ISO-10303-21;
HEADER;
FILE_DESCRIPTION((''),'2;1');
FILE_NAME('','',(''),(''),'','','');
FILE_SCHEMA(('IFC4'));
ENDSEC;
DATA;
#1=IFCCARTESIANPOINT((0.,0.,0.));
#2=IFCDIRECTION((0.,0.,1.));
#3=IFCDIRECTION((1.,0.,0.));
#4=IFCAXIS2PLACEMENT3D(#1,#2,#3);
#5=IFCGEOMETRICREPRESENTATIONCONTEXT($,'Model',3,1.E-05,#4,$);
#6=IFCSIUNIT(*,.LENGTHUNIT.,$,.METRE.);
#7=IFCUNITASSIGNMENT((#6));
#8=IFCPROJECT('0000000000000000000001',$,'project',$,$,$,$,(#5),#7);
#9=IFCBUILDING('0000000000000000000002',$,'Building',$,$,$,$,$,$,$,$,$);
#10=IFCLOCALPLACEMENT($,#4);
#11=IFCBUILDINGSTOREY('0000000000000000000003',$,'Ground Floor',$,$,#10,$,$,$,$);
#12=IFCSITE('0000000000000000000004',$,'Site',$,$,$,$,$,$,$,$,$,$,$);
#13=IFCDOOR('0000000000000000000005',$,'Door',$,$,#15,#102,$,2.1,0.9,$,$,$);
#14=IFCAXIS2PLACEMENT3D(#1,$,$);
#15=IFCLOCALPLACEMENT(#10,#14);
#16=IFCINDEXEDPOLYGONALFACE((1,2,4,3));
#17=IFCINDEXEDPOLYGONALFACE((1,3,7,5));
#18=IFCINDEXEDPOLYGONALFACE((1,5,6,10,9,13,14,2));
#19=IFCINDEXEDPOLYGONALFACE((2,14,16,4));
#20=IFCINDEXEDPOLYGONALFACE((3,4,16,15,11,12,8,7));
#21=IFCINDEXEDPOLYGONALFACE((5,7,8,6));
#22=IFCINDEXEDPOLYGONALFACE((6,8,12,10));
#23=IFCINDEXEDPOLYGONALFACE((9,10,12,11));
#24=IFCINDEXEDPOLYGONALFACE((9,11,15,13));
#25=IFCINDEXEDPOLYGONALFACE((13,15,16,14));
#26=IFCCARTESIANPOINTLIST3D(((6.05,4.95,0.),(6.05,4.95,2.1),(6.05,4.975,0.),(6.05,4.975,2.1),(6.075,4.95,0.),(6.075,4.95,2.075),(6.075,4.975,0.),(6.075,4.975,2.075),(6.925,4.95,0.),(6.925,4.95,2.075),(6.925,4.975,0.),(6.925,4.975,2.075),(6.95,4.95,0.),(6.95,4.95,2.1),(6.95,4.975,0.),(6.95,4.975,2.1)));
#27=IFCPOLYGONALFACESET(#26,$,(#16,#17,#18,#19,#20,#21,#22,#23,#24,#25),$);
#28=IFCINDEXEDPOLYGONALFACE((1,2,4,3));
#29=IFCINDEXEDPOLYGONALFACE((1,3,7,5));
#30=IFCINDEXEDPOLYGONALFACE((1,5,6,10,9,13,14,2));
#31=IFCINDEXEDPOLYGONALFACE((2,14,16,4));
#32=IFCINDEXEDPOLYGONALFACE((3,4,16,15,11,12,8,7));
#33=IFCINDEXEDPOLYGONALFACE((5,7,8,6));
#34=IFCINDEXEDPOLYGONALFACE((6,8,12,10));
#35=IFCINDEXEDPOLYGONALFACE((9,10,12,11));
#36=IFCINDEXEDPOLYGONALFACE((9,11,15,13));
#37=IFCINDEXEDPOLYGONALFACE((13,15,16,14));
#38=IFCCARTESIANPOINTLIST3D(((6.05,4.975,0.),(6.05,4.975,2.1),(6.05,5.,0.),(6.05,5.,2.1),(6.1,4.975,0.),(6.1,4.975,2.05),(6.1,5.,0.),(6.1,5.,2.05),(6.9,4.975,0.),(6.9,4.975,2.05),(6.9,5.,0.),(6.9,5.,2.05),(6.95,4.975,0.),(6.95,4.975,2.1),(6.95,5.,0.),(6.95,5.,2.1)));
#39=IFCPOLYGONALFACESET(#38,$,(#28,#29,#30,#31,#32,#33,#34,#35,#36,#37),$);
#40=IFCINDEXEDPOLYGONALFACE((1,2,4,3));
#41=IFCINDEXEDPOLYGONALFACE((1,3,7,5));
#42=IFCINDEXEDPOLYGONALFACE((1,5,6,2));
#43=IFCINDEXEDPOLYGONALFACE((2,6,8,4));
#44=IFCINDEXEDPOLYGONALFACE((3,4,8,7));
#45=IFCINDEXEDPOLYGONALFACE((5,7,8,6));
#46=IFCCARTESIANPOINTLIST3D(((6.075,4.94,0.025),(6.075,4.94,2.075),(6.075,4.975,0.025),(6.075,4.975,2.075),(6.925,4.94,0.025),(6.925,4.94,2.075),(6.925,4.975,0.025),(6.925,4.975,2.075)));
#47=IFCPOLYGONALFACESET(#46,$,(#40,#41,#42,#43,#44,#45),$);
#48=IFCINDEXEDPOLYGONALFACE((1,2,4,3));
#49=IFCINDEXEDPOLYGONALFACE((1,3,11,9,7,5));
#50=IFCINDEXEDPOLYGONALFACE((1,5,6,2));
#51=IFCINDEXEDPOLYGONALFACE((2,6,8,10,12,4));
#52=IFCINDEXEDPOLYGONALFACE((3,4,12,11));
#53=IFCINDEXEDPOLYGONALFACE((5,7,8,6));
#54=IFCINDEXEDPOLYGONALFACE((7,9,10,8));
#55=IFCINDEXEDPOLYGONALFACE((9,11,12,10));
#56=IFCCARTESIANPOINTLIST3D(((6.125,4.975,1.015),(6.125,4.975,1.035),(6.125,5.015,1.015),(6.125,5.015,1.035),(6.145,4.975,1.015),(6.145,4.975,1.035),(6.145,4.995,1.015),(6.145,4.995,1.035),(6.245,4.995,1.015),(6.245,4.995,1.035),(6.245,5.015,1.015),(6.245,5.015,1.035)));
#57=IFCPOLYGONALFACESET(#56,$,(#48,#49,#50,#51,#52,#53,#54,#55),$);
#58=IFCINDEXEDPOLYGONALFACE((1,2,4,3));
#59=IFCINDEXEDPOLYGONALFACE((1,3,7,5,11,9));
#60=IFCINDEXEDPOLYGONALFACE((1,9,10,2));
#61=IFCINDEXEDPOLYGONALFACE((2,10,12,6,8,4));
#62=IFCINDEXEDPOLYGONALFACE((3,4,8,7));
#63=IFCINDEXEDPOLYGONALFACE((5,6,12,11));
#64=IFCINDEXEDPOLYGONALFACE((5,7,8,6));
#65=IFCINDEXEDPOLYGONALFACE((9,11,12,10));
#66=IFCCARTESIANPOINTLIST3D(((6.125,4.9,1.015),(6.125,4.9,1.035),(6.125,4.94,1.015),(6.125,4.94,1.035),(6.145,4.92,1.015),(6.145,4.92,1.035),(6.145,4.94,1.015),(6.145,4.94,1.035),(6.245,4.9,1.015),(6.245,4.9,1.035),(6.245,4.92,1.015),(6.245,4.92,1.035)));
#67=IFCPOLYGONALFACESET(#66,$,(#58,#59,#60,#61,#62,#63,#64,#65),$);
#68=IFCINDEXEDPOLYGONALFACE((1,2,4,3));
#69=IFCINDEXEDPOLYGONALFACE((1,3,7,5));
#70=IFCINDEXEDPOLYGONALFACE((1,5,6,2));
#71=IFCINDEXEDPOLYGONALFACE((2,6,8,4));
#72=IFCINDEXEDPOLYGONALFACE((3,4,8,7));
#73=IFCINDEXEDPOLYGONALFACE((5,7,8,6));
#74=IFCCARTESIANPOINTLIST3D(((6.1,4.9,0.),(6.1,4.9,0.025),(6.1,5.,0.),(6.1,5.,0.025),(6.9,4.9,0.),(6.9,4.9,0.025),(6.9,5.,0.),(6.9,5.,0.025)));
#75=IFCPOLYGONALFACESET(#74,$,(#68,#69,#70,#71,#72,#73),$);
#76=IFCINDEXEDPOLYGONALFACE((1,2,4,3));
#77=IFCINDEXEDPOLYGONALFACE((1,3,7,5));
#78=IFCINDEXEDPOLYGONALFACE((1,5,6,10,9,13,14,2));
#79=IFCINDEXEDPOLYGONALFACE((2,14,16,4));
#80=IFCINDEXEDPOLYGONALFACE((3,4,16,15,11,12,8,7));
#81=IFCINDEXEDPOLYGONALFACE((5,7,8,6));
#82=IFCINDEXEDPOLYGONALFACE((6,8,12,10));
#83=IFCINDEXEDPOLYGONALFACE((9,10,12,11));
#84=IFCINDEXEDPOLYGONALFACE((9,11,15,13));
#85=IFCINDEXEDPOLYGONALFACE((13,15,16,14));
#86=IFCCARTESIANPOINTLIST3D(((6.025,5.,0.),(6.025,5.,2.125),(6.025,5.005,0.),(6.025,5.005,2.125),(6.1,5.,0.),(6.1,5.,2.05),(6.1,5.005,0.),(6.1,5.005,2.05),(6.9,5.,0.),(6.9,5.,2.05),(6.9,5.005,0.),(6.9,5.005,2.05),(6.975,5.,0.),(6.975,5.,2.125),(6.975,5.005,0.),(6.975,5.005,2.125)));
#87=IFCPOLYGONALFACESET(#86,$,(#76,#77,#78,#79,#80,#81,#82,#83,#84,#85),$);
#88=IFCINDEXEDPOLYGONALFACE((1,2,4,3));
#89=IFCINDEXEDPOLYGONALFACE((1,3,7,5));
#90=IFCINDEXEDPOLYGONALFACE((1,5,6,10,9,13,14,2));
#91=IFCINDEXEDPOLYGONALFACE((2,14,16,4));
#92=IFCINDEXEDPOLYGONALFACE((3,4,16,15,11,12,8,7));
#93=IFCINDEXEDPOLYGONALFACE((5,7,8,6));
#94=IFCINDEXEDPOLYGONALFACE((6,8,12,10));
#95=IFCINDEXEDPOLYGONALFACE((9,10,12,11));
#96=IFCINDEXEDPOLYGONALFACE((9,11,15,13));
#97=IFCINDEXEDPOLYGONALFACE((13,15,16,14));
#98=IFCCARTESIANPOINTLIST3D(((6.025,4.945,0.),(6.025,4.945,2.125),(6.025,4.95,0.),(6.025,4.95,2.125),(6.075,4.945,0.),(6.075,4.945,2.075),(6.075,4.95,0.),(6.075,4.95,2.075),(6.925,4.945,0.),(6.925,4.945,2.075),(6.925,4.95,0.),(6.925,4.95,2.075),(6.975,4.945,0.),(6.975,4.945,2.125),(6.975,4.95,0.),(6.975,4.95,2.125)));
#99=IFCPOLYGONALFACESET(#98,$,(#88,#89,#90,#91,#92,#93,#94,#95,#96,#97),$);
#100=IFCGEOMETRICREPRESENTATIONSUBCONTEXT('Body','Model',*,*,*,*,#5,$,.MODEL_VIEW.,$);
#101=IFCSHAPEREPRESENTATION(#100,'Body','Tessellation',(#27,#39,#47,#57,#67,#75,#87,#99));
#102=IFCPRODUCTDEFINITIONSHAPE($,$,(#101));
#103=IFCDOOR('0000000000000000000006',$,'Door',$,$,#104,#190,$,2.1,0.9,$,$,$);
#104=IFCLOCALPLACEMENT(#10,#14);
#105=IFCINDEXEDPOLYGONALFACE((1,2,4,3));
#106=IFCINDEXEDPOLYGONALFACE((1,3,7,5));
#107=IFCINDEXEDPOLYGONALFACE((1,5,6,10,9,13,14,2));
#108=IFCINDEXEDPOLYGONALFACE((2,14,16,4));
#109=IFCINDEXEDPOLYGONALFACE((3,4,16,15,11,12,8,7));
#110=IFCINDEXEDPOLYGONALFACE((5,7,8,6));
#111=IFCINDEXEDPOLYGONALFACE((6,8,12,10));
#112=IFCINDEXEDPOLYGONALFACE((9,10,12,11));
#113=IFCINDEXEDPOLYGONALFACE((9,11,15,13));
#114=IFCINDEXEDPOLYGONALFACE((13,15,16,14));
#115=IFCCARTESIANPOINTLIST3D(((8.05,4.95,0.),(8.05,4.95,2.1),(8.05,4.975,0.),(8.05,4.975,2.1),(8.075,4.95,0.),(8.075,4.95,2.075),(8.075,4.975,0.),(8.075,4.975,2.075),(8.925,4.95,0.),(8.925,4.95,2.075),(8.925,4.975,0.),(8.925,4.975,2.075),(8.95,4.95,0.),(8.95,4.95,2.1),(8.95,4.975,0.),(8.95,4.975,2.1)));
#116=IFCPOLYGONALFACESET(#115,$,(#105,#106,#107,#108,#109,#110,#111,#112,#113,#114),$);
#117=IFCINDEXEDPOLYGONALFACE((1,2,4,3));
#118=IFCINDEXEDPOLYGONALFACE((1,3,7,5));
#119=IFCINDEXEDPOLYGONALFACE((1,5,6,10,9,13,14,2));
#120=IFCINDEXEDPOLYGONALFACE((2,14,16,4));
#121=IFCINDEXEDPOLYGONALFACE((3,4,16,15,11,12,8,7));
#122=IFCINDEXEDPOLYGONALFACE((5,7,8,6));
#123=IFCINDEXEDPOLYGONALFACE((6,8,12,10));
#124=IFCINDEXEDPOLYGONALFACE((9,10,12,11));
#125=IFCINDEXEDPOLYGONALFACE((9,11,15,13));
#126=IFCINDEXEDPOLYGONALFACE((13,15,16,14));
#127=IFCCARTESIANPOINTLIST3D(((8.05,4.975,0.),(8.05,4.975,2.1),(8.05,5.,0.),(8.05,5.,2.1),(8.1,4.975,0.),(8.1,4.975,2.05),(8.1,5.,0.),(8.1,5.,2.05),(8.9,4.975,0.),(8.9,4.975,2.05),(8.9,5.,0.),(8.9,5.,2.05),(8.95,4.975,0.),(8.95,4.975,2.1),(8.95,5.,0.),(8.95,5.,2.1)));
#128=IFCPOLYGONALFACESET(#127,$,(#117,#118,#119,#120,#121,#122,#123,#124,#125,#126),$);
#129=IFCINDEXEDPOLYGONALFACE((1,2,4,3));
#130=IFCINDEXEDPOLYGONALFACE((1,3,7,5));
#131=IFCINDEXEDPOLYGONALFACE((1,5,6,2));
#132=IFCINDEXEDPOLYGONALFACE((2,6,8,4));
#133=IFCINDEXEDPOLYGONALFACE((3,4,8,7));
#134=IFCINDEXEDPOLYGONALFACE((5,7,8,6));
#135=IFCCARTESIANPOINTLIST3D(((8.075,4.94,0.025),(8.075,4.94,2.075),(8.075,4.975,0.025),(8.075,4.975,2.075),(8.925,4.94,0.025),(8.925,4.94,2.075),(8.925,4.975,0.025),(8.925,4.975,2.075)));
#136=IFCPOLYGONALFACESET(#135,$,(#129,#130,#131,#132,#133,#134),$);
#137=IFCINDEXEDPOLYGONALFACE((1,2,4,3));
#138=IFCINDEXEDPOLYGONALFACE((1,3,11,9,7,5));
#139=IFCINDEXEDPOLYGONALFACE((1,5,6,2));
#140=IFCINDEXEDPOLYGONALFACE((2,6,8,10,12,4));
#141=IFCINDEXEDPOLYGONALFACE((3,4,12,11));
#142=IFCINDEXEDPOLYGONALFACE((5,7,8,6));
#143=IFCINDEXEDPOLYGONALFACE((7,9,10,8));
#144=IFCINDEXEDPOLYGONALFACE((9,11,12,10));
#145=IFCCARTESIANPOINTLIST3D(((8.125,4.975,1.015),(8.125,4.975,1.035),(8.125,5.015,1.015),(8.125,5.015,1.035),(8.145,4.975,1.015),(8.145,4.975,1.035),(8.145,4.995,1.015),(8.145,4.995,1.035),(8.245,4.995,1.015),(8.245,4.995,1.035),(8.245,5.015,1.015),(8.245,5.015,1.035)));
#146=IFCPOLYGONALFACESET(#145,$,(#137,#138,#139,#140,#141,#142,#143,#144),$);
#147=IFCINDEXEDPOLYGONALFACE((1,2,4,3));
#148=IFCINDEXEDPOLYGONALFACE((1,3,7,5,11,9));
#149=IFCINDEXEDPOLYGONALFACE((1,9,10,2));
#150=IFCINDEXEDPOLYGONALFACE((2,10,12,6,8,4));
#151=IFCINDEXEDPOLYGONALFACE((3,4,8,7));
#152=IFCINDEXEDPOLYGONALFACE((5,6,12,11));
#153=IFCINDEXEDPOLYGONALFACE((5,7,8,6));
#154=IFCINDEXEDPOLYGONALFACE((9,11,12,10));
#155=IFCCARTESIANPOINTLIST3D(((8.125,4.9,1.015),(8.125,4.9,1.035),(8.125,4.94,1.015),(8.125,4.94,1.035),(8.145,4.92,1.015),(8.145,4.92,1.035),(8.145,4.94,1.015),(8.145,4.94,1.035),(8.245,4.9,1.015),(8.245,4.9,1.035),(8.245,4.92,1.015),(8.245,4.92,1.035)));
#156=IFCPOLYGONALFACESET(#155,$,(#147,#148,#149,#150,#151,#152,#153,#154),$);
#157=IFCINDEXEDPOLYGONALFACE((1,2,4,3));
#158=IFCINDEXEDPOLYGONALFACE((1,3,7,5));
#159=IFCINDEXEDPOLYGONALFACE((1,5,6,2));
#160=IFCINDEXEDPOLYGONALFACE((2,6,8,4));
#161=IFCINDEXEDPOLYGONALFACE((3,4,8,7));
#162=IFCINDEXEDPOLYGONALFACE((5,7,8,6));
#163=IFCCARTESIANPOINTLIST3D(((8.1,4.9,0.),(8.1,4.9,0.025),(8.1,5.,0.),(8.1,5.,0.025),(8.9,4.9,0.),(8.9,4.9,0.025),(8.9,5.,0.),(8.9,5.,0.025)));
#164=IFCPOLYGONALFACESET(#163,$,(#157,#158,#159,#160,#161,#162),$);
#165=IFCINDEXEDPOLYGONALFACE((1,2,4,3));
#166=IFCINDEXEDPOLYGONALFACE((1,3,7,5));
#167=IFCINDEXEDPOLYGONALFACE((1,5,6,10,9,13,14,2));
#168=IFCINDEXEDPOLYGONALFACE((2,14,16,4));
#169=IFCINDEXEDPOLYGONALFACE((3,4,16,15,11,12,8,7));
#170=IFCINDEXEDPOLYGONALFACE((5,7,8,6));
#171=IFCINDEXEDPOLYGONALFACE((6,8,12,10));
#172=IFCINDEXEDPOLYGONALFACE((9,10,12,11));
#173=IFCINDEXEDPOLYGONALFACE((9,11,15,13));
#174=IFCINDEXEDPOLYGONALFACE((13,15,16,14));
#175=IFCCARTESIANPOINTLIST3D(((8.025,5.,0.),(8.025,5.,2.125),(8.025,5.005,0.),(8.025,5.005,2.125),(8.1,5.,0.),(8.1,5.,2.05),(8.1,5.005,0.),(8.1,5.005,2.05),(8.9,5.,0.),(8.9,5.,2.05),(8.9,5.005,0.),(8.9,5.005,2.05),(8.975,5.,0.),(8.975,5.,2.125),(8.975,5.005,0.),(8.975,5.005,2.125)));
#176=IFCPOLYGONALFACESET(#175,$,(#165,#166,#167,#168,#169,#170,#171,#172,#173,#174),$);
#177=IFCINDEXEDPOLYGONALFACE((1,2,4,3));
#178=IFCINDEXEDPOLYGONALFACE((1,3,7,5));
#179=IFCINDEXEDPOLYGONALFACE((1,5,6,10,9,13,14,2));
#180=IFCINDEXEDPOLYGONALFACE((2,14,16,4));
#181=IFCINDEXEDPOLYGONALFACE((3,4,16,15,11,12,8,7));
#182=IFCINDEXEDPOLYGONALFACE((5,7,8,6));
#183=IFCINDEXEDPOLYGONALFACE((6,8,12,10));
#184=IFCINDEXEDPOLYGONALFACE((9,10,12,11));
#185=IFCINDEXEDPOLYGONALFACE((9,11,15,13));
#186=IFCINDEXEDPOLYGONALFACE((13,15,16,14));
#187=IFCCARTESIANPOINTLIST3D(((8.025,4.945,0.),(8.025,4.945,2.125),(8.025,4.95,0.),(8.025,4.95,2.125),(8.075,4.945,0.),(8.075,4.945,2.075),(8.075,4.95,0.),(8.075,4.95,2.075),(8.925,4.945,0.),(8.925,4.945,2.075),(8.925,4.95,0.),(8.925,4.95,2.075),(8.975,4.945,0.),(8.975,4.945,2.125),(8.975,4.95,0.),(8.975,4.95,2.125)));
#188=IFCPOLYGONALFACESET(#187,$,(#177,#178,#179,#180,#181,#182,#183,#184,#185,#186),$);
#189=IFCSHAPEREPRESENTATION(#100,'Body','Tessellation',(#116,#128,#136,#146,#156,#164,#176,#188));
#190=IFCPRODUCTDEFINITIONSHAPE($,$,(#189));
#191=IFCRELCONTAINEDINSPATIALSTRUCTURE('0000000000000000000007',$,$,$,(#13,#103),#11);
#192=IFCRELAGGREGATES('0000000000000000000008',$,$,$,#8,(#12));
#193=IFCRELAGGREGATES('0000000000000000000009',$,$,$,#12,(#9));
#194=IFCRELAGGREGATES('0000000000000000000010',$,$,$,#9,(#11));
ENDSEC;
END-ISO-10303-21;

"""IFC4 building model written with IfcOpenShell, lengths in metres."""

from ifc_helpers import new_model, si_unit, frame, origin_with_axes, place, context, subcontext, project, spatial, line, indexed_curve, outline, extrude, element, save


model = new_model("IFC4")

# Units and contexts
model_context = context("Model", 3, precision=1e-05, world=origin_with_axes())
body_context = subcontext(model_context, "Body", "Model", "MODEL_VIEW")
ifc_project = project(units=[si_unit("LENGTHUNIT", "METRE")], contexts=[model_context])

# Site, building, storey
site = spatial("IfcSite", under=ifc_project, Name="Site")
building = spatial("IfcBuilding", under=site, Name="Building")
storey_placement = place(None, origin_with_axes())
storey = spatial("IfcBuildingStorey", under=building, at=storey_placement, Name="Ground Floor")

# Doors
door_1_placement = place(storey_placement, frame((6.95, 5.0, 0.0), z_axis=(0.0, 0.0, 1.0), x_axis=(-1.0, 0.0, 0.0)))
element("IfcDoor", 1, at=door_1_placement, inside=storey, Name="Door", OverallHeight=2.1, OverallWidth=0.9, context=body_context, shape_type="SweptSolid", body=[
    extrude(outline(indexed_curve([(0.0, 0.0), (0.0, 2.1), (0.9, 2.1), (0.9, 0.0), (0.875, 0.0), (0.875, 2.075), (0.025, 2.075), (0.025, 0.0)], segments=[line(1, 2, 3, 4, 5, 6, 7, 8, 1)])), frame((0.0, 0.025, 0.0), z_axis=(0.0, -1.0, 0.0), x_axis=(1.0, 0.0, 0.0)), (0.0, 0.0, -1.0), 0.025),
    extrude(outline(indexed_curve([(0.0, 0.0), (0.0, 2.1), (0.9, 2.1), (0.9, 0.0), (0.85, 0.0), (0.85, 2.05), (0.05, 2.05), (0.05, 0.0)], segments=[line(1, 2, 3, 4, 5, 6, 7, 8, 1)])), frame((0.0, 0.0, 0.0), z_axis=(0.0, -1.0, 0.0), x_axis=(1.0, 0.0, 0.0)), (0.0, 0.0, -1.0), 0.025),
    extrude(outline(indexed_curve([(0.0, 0.0), (0.85, 0.0), (0.85, 0.035), (0.0, 0.035)], segments=[line(1, 2, 3, 4, 1)])), frame((0.025, 0.025, 0.025), z_axis=(0.0, 0.0, 1.0), x_axis=(1.0, 0.0, 0.0)), (0.0, 0.0, 1.0), 2.05),
    extrude(outline(indexed_curve([(0.0, 0.0), (0.0, -0.04), (-0.12, -0.04), (-0.12, -0.02), (-0.02, -0.02), (-0.02, 0.0)], segments=[line(1, 2, 3, 4, 5, 6, 1)])), frame((0.825, 0.025, 1.015), z_axis=(0.0, 0.0, 1.0), x_axis=(1.0, 0.0, 0.0)), (0.0, 0.0, 1.0), 0.02),
    extrude(outline(indexed_curve([(0.0, 0.0), (0.0, 0.04), (-0.12, 0.04), (-0.12, 0.02), (-0.02, 0.02), (-0.02, 0.0)], segments=[line(1, 2, 3, 4, 5, 6, 1)])), frame((0.825, 0.06, 1.015), z_axis=(0.0, 0.0, 1.0), x_axis=(1.0, 0.0, 0.0)), (0.0, 0.0, 1.0), 0.02),
    extrude(outline(indexed_curve([(0.0, 0.0), (0.8, 0.0), (0.8, 0.1), (0.0, 0.1)], segments=[line(1, 2, 3, 4, 1)])), frame((0.05, 0.0, 0.0), z_axis=(0.0, 0.0, 1.0), x_axis=(1.0, 0.0, 0.0)), (0.0, 0.0, 1.0), 0.025),
    extrude(outline(indexed_curve([(0.0, 0.0), (0.0, 2.125), (0.95, 2.125), (0.95, 0.0), (0.875, 0.0), (0.875, 2.05), (0.075, 2.05), (0.075, 0.0)], segments=[line(1, 2, 3, 4, 5, 6, 7, 8, 1)])), frame((-0.025, -0.005, 0.0), z_axis=(0.0, -1.0, 0.0), x_axis=(1.0, 0.0, 0.0)), (0.0, 0.0, -1.0), 0.005),
    extrude(outline(indexed_curve([(0.0, 0.0), (0.0, 2.125), (0.95, 2.125), (0.95, 0.0), (0.9, 0.0), (0.9, 2.075), (0.05, 2.075), (0.05, 0.0)], segments=[line(1, 2, 3, 4, 5, 6, 7, 8, 1)])), frame((-0.025, 0.05, 0.0), z_axis=(0.0, -1.0, 0.0), x_axis=(1.0, 0.0, 0.0)), (0.0, 0.0, -1.0), 0.005),
])
door_2_placement = place(storey_placement, frame((8.95, 5.0, 0.0), z_axis=(0.0, 0.0, 1.0), x_axis=(-1.0, 0.0, 0.0)))
element("IfcDoor", 2, at=door_2_placement, inside=storey, Name="Door", OverallHeight=2.1, OverallWidth=0.9, context=body_context, shape_type="SweptSolid", body=[
    extrude(outline(indexed_curve([(0.0, 0.0), (0.0, 2.1), (0.9, 2.1), (0.9, 0.0), (0.875, 0.0), (0.875, 2.075), (0.025, 2.075), (0.025, 0.0)], segments=[line(1, 2, 3, 4, 5, 6, 7, 8, 1)])), frame((0.0, 0.025, 0.0), z_axis=(0.0, -1.0, 0.0), x_axis=(1.0, 0.0, 0.0)), (0.0, 0.0, -1.0), 0.025),
    extrude(outline(indexed_curve([(0.0, 0.0), (0.0, 2.1), (0.9, 2.1), (0.9, 0.0), (0.85, 0.0), (0.85, 2.05), (0.05, 2.05), (0.05, 0.0)], segments=[line(1, 2, 3, 4, 5, 6, 7, 8, 1)])), frame((0.0, 0.0, 0.0), z_axis=(0.0, -1.0, 0.0), x_axis=(1.0, 0.0, 0.0)), (0.0, 0.0, -1.0), 0.025),
    extrude(outline(indexed_curve([(0.0, 0.0), (0.85, 0.0), (0.85, 0.035), (0.0, 0.035)], segments=[line(1, 2, 3, 4, 1)])), frame((0.025, 0.025, 0.025), z_axis=(0.0, 0.0, 1.0), x_axis=(1.0, 0.0, 0.0)), (0.0, 0.0, 1.0), 2.05),
    extrude(outline(indexed_curve([(0.0, 0.0), (0.0, -0.04), (-0.12, -0.04), (-0.12, -0.02), (-0.02, -0.02), (-0.02, 0.0)], segments=[line(1, 2, 3, 4, 5, 6, 1)])), frame((0.825, 0.025, 1.015), z_axis=(0.0, 0.0, 1.0), x_axis=(1.0, 0.0, 0.0)), (0.0, 0.0, 1.0), 0.02),
    extrude(outline(indexed_curve([(0.0, 0.0), (0.0, 0.04), (-0.12, 0.04), (-0.12, 0.02), (-0.02, 0.02), (-0.02, 0.0)], segments=[line(1, 2, 3, 4, 5, 6, 1)])), frame((0.825, 0.06, 1.015), z_axis=(0.0, 0.0, 1.0), x_axis=(1.0, 0.0, 0.0)), (0.0, 0.0, 1.0), 0.02),
    extrude(outline(indexed_curve([(0.0, 0.0), (0.8, 0.0), (0.8, 0.1), (0.0, 0.1)], segments=[line(1, 2, 3, 4, 1)])), frame((0.05, 0.0, 0.0), z_axis=(0.0, 0.0, 1.0), x_axis=(1.0, 0.0, 0.0)), (0.0, 0.0, 1.0), 0.025),
    extrude(outline(indexed_curve([(0.0, 0.0), (0.0, 2.125), (0.95, 2.125), (0.95, 0.0), (0.875, 0.0), (0.875, 2.05), (0.075, 2.05), (0.075, 0.0)], segments=[line(1, 2, 3, 4, 5, 6, 7, 8, 1)])), frame((-0.025, -0.005, 0.0), z_axis=(0.0, -1.0, 0.0), x_axis=(1.0, 0.0, 0.0)), (0.0, 0.0, -1.0), 0.005),
    extrude(outline(indexed_curve([(0.0, 0.0), (0.0, 2.125), (0.95, 2.125), (0.95, 0.0), (0.9, 0.0), (0.9, 2.075), (0.05, 2.075), (0.05, 0.0)], segments=[line(1, 2, 3, 4, 5, 6, 7, 8, 1)])), frame((-0.025, 0.05, 0.0), z_axis=(0.0, -1.0, 0.0), x_axis=(1.0, 0.0, 0.0)), (0.0, 0.0, -1.0), 0.005),
])

save(model, "model.ifc")
